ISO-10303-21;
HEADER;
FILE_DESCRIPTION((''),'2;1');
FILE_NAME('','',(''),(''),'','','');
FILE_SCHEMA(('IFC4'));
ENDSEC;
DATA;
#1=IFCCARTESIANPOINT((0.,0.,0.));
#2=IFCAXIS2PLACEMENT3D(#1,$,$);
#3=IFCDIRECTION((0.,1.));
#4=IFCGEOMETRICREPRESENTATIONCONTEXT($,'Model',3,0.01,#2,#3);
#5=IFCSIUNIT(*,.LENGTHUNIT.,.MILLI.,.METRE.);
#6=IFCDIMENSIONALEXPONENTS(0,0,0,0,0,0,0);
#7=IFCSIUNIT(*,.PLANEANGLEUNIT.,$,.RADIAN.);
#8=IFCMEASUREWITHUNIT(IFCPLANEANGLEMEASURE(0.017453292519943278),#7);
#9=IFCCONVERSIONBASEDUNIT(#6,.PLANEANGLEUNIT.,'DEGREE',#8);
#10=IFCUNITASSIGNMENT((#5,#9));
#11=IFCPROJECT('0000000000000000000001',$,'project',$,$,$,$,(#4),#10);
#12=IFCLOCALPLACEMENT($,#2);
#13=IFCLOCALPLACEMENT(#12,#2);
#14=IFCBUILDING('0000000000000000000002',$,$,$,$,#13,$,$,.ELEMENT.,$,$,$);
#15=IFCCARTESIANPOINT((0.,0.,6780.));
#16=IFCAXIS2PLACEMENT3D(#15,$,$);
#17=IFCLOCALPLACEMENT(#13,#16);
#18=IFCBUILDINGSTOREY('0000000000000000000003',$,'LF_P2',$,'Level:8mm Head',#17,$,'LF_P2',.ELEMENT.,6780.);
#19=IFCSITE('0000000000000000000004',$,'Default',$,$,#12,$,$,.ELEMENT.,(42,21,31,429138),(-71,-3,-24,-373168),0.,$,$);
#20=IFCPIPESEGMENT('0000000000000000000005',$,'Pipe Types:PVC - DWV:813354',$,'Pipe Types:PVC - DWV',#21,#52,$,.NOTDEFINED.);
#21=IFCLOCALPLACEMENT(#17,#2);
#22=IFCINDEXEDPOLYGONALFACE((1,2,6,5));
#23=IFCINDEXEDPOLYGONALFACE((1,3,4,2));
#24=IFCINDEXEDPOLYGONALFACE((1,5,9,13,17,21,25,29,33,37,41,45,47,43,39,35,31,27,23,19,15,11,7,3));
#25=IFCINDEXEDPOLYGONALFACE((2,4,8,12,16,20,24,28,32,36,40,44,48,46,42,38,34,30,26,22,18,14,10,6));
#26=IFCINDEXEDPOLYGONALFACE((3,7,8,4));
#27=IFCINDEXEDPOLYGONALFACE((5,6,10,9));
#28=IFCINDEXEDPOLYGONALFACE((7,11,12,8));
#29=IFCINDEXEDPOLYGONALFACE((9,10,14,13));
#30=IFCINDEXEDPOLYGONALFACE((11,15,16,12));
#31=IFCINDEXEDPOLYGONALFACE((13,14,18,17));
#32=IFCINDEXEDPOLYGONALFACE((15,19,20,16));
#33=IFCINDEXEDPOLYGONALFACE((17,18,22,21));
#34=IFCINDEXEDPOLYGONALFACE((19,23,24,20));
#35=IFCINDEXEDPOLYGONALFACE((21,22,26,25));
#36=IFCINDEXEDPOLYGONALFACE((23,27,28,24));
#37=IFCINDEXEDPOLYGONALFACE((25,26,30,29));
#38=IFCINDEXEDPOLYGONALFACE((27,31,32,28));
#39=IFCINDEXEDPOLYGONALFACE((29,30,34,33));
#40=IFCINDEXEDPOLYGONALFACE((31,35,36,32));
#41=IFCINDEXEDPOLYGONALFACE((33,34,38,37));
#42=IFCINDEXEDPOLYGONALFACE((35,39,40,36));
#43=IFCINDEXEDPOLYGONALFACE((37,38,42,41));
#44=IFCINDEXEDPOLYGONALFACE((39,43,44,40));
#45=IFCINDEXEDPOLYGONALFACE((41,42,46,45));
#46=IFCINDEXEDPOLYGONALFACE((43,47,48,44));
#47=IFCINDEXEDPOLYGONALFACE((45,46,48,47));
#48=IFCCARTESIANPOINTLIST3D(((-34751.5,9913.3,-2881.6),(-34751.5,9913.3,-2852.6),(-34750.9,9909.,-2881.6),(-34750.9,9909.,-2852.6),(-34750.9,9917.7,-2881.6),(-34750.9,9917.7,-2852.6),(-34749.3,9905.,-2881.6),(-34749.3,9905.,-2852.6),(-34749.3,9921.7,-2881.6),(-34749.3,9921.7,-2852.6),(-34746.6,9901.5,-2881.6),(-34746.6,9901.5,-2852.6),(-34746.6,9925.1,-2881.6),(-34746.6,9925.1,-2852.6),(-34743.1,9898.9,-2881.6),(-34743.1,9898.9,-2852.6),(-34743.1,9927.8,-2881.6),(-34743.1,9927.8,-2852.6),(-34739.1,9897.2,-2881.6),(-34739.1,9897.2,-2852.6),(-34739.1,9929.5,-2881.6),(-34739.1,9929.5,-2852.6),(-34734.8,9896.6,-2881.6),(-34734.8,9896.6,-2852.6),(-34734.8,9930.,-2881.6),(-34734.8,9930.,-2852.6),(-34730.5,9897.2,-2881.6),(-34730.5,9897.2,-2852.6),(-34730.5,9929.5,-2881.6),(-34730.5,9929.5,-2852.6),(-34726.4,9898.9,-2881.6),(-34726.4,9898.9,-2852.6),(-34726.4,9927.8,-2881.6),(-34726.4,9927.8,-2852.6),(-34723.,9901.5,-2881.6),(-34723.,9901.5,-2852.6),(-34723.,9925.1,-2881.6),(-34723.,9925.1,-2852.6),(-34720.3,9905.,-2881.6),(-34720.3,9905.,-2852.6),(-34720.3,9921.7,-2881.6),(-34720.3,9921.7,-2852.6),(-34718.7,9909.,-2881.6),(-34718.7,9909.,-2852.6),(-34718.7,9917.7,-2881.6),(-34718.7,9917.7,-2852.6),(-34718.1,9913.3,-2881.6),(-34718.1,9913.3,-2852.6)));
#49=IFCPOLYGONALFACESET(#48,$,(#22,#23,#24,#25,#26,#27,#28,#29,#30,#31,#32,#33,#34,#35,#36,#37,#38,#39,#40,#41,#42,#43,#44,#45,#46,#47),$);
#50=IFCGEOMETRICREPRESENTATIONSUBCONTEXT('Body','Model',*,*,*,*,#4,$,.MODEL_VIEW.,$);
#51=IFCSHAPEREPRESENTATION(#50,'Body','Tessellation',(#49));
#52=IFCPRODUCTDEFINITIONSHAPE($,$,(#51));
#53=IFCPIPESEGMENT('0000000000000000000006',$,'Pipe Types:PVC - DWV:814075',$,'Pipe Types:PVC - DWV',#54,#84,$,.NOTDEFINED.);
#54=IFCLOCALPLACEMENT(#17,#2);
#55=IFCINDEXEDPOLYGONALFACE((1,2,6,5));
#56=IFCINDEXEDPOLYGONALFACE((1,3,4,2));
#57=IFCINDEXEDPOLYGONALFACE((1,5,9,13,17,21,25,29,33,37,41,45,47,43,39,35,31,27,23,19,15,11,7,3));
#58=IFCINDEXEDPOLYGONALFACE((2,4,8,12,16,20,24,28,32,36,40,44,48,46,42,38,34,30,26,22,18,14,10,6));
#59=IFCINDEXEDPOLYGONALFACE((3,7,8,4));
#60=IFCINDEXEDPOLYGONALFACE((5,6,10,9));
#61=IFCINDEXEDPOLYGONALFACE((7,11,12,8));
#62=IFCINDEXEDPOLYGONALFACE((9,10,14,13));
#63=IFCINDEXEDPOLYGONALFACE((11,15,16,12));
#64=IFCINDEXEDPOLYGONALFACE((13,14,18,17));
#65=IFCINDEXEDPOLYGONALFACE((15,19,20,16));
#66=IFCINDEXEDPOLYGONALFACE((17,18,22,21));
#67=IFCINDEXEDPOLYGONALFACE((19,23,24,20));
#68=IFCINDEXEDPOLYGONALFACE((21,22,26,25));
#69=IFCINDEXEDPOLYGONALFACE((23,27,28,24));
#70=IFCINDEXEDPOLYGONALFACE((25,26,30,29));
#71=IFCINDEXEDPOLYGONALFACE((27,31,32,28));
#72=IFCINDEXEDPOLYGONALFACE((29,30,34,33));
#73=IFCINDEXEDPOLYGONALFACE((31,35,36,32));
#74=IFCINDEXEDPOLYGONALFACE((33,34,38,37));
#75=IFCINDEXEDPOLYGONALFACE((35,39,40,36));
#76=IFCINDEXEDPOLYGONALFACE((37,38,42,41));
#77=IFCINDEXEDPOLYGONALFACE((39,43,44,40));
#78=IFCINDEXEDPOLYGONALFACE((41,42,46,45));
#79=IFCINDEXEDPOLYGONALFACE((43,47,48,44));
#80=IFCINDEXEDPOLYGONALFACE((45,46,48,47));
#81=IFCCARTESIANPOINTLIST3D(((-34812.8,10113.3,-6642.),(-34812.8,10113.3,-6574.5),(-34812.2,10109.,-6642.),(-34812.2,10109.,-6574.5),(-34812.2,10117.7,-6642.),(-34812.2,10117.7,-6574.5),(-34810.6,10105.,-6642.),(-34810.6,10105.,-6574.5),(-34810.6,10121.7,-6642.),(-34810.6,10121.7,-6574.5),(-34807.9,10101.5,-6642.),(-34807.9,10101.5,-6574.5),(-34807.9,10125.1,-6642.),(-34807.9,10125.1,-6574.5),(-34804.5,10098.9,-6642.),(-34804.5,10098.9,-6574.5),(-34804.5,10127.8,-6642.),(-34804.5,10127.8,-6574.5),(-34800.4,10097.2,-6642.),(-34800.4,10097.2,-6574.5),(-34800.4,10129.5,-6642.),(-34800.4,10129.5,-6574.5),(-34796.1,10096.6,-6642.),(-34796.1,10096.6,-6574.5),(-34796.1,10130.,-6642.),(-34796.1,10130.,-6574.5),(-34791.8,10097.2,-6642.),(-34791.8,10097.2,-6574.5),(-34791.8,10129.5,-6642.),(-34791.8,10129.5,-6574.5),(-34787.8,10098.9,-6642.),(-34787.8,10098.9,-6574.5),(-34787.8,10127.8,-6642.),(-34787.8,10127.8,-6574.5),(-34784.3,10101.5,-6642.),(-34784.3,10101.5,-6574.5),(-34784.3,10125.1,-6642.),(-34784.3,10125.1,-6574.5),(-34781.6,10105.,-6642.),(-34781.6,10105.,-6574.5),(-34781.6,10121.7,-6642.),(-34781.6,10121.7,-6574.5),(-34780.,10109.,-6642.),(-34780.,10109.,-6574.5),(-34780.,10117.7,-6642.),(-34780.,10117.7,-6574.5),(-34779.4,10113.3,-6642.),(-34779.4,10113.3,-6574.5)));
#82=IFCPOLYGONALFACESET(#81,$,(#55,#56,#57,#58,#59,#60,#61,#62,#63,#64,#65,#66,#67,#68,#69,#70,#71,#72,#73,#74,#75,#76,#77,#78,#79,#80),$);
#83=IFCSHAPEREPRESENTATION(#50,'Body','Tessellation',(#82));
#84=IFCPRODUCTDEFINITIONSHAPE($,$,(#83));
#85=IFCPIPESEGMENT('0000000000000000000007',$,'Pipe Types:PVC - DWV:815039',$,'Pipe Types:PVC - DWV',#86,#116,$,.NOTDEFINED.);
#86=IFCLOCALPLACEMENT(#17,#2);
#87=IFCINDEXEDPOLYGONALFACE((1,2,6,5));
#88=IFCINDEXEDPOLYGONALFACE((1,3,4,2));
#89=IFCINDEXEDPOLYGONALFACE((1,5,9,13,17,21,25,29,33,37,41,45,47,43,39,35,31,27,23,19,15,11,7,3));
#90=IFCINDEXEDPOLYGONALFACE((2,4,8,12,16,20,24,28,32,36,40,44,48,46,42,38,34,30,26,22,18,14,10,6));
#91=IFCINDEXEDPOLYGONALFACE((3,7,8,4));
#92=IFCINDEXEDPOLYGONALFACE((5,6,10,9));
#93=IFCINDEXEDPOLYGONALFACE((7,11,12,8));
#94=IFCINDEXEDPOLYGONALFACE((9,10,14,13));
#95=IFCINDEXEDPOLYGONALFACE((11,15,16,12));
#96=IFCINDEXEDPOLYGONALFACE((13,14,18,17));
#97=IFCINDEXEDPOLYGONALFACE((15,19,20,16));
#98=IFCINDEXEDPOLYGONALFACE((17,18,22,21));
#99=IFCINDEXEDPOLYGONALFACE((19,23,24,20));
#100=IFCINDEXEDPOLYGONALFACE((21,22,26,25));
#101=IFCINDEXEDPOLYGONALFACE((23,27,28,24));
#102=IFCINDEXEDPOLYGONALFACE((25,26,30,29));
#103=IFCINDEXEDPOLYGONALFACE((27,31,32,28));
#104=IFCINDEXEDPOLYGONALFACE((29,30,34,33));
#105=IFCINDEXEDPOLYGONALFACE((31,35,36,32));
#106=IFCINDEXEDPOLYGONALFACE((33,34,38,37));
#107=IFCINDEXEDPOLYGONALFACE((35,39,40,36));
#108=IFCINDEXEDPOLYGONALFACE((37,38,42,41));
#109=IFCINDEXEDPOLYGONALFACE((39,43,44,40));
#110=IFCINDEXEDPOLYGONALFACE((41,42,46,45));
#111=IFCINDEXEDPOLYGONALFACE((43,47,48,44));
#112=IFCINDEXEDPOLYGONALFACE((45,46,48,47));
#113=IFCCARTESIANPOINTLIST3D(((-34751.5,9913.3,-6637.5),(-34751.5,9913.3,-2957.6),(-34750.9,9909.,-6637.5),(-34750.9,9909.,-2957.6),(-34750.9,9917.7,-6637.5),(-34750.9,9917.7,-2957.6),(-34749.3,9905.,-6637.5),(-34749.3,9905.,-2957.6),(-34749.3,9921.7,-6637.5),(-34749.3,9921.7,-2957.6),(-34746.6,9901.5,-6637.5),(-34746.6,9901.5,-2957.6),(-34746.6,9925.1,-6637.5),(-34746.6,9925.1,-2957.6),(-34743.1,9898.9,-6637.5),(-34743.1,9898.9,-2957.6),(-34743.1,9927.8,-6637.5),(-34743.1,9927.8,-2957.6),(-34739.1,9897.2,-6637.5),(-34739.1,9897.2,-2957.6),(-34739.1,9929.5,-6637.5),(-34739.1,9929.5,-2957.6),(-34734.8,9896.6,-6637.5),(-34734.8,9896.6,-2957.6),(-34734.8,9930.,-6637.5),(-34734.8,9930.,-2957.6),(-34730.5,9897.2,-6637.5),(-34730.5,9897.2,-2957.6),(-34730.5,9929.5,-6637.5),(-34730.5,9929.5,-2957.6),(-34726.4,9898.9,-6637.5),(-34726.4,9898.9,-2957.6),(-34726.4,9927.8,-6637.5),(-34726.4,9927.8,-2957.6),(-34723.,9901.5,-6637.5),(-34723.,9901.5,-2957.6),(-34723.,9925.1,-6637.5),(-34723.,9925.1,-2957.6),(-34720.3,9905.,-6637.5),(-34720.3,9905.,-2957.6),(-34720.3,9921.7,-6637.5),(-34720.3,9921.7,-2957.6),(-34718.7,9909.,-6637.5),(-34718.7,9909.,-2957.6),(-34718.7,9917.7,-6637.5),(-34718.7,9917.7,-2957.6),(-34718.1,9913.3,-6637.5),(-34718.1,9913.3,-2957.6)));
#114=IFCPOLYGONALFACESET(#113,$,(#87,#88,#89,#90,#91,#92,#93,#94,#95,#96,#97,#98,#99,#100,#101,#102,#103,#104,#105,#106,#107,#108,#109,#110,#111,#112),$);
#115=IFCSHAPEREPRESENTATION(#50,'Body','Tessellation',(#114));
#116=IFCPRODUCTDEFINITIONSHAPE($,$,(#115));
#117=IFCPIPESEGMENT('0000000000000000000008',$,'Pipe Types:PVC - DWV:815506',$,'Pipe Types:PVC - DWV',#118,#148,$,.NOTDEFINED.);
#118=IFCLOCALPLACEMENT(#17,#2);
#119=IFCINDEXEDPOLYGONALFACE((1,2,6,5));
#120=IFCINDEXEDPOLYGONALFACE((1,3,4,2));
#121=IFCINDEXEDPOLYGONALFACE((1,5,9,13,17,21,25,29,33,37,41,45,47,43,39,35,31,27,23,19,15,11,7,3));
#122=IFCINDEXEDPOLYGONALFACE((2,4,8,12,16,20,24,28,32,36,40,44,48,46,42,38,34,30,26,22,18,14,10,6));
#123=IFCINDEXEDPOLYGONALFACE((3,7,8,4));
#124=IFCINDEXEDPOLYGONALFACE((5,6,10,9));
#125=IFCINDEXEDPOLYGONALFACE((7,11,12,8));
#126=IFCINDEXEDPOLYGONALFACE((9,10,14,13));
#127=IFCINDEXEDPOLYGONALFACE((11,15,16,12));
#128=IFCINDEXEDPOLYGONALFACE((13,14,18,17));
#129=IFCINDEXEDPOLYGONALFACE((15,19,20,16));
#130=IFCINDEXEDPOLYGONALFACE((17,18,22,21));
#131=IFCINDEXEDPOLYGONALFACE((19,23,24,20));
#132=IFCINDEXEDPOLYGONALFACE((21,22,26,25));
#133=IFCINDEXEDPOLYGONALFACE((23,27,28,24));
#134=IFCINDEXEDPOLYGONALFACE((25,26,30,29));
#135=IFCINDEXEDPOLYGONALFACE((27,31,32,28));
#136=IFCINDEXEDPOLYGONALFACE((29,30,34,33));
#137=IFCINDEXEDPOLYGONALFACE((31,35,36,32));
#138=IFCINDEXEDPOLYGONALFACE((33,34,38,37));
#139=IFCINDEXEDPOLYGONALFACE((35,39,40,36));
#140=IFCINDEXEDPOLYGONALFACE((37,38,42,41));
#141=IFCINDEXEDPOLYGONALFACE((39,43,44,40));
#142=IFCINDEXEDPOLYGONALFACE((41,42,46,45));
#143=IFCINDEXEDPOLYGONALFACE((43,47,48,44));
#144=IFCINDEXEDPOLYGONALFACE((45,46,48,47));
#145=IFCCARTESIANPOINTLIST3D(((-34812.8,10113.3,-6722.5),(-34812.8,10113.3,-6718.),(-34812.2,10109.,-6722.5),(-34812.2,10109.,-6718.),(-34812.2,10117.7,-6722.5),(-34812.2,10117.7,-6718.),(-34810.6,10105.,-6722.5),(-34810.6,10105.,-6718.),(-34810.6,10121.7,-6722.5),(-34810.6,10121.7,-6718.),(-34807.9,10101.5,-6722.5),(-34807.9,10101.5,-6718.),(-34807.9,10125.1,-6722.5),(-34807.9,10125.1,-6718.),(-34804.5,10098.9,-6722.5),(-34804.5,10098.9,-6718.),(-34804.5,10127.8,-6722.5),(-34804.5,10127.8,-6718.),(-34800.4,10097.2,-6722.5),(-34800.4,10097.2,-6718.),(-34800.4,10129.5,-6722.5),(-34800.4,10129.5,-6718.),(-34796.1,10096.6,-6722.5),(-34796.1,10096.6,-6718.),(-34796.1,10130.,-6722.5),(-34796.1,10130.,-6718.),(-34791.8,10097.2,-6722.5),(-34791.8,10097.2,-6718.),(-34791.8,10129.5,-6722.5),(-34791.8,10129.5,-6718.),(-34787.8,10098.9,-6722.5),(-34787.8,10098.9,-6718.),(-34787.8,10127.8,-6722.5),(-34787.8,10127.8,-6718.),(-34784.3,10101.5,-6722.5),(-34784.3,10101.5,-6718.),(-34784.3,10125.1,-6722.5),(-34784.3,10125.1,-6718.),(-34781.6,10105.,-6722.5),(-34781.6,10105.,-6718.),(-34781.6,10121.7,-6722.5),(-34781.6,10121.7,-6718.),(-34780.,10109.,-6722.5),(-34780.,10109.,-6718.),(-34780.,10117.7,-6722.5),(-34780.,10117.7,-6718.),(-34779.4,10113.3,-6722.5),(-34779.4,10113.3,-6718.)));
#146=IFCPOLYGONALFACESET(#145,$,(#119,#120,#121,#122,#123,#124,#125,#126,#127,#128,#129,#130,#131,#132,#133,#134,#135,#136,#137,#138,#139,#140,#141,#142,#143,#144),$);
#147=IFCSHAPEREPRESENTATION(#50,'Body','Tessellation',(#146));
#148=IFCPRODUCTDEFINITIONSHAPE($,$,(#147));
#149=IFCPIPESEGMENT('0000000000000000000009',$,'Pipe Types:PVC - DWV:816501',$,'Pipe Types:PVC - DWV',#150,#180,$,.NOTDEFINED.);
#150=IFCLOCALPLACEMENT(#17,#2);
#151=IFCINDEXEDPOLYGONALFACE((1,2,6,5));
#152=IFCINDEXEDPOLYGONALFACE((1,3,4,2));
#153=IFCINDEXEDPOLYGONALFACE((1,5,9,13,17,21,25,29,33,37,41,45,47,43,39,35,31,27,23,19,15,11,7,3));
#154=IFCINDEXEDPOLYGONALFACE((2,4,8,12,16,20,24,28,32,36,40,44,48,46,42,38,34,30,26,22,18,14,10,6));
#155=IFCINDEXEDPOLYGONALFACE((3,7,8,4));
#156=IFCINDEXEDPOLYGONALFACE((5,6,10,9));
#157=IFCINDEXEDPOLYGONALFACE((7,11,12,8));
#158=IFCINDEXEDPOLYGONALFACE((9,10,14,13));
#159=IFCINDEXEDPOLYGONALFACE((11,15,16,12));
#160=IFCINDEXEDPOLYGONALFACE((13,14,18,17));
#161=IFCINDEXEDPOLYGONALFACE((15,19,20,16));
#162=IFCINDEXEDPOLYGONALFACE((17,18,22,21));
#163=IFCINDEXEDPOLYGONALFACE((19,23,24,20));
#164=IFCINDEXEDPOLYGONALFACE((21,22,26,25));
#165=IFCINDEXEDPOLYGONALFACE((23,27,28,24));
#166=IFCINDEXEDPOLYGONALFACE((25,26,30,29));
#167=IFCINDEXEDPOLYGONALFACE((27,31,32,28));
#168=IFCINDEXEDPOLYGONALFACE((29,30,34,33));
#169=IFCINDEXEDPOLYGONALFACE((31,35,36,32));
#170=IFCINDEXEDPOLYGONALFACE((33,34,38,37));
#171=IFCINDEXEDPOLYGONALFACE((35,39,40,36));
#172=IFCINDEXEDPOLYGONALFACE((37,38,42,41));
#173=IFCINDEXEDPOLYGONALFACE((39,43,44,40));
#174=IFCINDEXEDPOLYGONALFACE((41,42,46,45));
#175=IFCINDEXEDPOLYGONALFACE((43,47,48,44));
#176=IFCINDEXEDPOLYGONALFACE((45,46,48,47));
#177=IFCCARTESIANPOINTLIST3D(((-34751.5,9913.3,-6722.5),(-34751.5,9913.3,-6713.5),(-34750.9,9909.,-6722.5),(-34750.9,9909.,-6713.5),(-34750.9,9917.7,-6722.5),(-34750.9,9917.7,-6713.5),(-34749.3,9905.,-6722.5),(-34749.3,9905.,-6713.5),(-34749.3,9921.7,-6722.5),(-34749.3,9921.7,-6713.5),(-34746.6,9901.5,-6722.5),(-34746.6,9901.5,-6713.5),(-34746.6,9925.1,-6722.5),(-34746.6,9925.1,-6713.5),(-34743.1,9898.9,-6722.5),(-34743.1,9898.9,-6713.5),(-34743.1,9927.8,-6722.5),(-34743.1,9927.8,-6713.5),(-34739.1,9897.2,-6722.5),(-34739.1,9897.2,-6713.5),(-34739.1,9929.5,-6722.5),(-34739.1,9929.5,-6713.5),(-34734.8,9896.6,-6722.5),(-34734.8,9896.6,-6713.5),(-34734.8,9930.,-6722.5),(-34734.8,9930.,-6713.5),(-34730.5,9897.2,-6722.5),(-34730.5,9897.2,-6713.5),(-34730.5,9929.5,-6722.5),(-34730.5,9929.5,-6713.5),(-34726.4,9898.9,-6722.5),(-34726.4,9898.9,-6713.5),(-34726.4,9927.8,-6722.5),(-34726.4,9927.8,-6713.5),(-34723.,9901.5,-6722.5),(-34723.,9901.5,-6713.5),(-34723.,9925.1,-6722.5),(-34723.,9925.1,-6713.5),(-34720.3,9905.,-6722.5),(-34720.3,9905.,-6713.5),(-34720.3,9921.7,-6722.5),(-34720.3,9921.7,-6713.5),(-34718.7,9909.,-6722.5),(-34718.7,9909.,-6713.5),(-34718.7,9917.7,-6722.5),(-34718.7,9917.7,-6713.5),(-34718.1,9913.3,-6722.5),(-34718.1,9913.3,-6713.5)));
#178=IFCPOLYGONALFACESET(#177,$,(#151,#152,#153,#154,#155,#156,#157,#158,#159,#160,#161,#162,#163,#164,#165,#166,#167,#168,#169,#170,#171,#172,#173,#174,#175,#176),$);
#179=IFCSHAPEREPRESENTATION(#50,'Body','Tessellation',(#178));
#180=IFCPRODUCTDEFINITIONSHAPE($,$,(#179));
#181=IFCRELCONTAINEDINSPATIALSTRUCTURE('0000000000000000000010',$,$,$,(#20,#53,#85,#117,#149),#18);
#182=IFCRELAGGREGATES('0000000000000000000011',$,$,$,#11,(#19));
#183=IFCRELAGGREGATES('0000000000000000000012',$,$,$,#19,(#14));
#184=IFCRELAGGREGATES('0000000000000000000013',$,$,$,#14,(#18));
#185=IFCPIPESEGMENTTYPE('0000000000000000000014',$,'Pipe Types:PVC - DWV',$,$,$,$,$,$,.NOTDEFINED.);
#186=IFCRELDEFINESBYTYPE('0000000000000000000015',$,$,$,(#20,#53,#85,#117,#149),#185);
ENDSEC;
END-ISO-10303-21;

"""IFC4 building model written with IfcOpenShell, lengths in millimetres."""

from ifc_helpers import new_model, entity, si_unit, converted_unit, direction, frame, origin, place, context, subcontext, project, spatial, arc, indexed_curve, outline, extrude, type_object, element, save


model = new_model("IFC4")

# Units and contexts
model_context = context("Model", 3, precision=0.01, world=origin(), true_north=direction((0.0, 1.0)))
body_context = subcontext(model_context, "Body", "Model", "MODEL_VIEW")
ifc_project = project(units=[si_unit("LENGTHUNIT", "METRE", prefix="MILLI"), converted_unit("PLANEANGLEUNIT", "DEGREE", entity("IfcPlaneAngleMeasure", 0.017453292519943278), si_unit("PLANEANGLEUNIT", "RADIAN"), dimensions=[0, 0, 0, 0, 0, 0, 0])], contexts=[model_context])

# Site, building, storey
site_placement = place(None, origin())
site = spatial("IfcSite", under=ifc_project, at=site_placement, Name="Default", CompositionType="ELEMENT", RefLatitude=(42, 21, 31, 429138), RefLongitude=(-71, -3, -24, -373168), RefElevation=0.0)
building_placement = place(site_placement, origin())
building = spatial("IfcBuilding", under=site, at=building_placement, CompositionType="ELEMENT")
storey_placement = place(building_placement, frame((0.0, 0.0, 6780.0)))
storey = spatial("IfcBuildingStorey", under=building, at=storey_placement, Name="LF_P2", ObjectType="Level:8mm Head", LongName="LF_P2", CompositionType="ELEMENT", Elevation=6780.0)

# Pipe segments
pipe_segment_type_1 = type_object("IfcPipeSegmentType", Name="Pipe Types:PVC - DWV", PredefinedType="NOTDEFINED")
pipe_segment_1_placement = place(storey_placement, origin())
element("IfcPipeSegment", 1, at=pipe_segment_1_placement, inside=storey, type_object=pipe_segment_type_1, Name="Pipe Types:PVC - DWV:813354", ObjectType="Pipe Types:PVC - DWV", PredefinedType="NOTDEFINED", context=body_context, shape_type="SweptSolid", body=[
    extrude(outline(indexed_curve([(16.7, 0.0), (11.8, 11.8), (0.0, 16.7), (-11.8, 11.8), (-16.7, 0.0), (-11.8, -11.8), (0.0, -16.7), (11.8, -11.8)], segments=[arc(1, 2, 3), arc(3, 4, 5), arc(5, 6, 7), arc(7, 8, 1)], self_intersect=False)), frame((-34734.8, 9913.3, -2881.6)), (0.0, 0.0, 1.0), 29.0),
])
pipe_segment_2_placement = place(storey_placement, origin())
element("IfcPipeSegment", 2, at=pipe_segment_2_placement, inside=storey, type_object=pipe_segment_type_1, Name="Pipe Types:PVC - DWV:814075", ObjectType="Pipe Types:PVC - DWV", PredefinedType="NOTDEFINED", context=body_context, shape_type="SweptSolid", body=[
    extrude(outline(indexed_curve([(16.7, 0.0), (11.8, 11.8), (0.0, 16.7), (-11.8, 11.8), (-16.7, 0.0), (-11.8, -11.8), (0.0, -16.7), (11.8, -11.8)], segments=[arc(1, 2, 3), arc(3, 4, 5), arc(5, 6, 7), arc(7, 8, 1)], self_intersect=False)), frame((-34796.1, 10113.3, -6642.0)), (0.0, 0.0, 1.0), 67.5),
])
pipe_segment_3_placement = place(storey_placement, origin())
element("IfcPipeSegment", 3, at=pipe_segment_3_placement, inside=storey, type_object=pipe_segment_type_1, Name="Pipe Types:PVC - DWV:815039", ObjectType="Pipe Types:PVC - DWV", PredefinedType="NOTDEFINED", context=body_context, shape_type="SweptSolid", body=[
    extrude(outline(indexed_curve([(16.7, 0.0), (11.8, 11.8), (0.0, 16.7), (-11.8, 11.8), (-16.7, 0.0), (-11.8, -11.8), (0.0, -16.7), (11.8, -11.8)], segments=[arc(1, 2, 3), arc(3, 4, 5), arc(5, 6, 7), arc(7, 8, 1)], self_intersect=False)), frame((-34734.8, 9913.3, -6637.5)), (0.0, 0.0, 1.0), 3679.9),
])
pipe_segment_4_placement = place(storey_placement, origin())
element("IfcPipeSegment", 4, at=pipe_segment_4_placement, inside=storey, type_object=pipe_segment_type_1, Name="Pipe Types:PVC - DWV:815506", ObjectType="Pipe Types:PVC - DWV", PredefinedType="NOTDEFINED", context=body_context, shape_type="SweptSolid", body=[
    extrude(outline(indexed_curve([(16.7, 0.0), (11.8, 11.8), (0.0, 16.7), (-11.8, 11.8), (-16.7, 0.0), (-11.8, -11.8), (0.0, -16.7), (11.8, -11.8)], segments=[arc(1, 2, 3), arc(3, 4, 5), arc(5, 6, 7), arc(7, 8, 1)], self_intersect=False)), frame((-34796.1, 10113.3, -6722.5)), (0.0, 0.0, 1.0), 4.5),
])
pipe_segment_5_placement = place(storey_placement, origin())
element("IfcPipeSegment", 5, at=pipe_segment_5_placement, inside=storey, type_object=pipe_segment_type_1, Name="Pipe Types:PVC - DWV:816501", ObjectType="Pipe Types:PVC - DWV", PredefinedType="NOTDEFINED", context=body_context, shape_type="SweptSolid", body=[
    extrude(outline(indexed_curve([(16.7, 0.0), (11.8, 11.8), (0.0, 16.7), (-11.8, 11.8), (-16.7, 0.0), (-11.8, -11.8), (0.0, -16.7), (11.8, -11.8)], segments=[arc(1, 2, 3), arc(3, 4, 5), arc(5, 6, 7), arc(7, 8, 1)], self_intersect=False)), frame((-34734.8, 9913.3, -6722.5)), (0.0, 0.0, 1.0), 9.0),
])

save(model, "model.ifc")
